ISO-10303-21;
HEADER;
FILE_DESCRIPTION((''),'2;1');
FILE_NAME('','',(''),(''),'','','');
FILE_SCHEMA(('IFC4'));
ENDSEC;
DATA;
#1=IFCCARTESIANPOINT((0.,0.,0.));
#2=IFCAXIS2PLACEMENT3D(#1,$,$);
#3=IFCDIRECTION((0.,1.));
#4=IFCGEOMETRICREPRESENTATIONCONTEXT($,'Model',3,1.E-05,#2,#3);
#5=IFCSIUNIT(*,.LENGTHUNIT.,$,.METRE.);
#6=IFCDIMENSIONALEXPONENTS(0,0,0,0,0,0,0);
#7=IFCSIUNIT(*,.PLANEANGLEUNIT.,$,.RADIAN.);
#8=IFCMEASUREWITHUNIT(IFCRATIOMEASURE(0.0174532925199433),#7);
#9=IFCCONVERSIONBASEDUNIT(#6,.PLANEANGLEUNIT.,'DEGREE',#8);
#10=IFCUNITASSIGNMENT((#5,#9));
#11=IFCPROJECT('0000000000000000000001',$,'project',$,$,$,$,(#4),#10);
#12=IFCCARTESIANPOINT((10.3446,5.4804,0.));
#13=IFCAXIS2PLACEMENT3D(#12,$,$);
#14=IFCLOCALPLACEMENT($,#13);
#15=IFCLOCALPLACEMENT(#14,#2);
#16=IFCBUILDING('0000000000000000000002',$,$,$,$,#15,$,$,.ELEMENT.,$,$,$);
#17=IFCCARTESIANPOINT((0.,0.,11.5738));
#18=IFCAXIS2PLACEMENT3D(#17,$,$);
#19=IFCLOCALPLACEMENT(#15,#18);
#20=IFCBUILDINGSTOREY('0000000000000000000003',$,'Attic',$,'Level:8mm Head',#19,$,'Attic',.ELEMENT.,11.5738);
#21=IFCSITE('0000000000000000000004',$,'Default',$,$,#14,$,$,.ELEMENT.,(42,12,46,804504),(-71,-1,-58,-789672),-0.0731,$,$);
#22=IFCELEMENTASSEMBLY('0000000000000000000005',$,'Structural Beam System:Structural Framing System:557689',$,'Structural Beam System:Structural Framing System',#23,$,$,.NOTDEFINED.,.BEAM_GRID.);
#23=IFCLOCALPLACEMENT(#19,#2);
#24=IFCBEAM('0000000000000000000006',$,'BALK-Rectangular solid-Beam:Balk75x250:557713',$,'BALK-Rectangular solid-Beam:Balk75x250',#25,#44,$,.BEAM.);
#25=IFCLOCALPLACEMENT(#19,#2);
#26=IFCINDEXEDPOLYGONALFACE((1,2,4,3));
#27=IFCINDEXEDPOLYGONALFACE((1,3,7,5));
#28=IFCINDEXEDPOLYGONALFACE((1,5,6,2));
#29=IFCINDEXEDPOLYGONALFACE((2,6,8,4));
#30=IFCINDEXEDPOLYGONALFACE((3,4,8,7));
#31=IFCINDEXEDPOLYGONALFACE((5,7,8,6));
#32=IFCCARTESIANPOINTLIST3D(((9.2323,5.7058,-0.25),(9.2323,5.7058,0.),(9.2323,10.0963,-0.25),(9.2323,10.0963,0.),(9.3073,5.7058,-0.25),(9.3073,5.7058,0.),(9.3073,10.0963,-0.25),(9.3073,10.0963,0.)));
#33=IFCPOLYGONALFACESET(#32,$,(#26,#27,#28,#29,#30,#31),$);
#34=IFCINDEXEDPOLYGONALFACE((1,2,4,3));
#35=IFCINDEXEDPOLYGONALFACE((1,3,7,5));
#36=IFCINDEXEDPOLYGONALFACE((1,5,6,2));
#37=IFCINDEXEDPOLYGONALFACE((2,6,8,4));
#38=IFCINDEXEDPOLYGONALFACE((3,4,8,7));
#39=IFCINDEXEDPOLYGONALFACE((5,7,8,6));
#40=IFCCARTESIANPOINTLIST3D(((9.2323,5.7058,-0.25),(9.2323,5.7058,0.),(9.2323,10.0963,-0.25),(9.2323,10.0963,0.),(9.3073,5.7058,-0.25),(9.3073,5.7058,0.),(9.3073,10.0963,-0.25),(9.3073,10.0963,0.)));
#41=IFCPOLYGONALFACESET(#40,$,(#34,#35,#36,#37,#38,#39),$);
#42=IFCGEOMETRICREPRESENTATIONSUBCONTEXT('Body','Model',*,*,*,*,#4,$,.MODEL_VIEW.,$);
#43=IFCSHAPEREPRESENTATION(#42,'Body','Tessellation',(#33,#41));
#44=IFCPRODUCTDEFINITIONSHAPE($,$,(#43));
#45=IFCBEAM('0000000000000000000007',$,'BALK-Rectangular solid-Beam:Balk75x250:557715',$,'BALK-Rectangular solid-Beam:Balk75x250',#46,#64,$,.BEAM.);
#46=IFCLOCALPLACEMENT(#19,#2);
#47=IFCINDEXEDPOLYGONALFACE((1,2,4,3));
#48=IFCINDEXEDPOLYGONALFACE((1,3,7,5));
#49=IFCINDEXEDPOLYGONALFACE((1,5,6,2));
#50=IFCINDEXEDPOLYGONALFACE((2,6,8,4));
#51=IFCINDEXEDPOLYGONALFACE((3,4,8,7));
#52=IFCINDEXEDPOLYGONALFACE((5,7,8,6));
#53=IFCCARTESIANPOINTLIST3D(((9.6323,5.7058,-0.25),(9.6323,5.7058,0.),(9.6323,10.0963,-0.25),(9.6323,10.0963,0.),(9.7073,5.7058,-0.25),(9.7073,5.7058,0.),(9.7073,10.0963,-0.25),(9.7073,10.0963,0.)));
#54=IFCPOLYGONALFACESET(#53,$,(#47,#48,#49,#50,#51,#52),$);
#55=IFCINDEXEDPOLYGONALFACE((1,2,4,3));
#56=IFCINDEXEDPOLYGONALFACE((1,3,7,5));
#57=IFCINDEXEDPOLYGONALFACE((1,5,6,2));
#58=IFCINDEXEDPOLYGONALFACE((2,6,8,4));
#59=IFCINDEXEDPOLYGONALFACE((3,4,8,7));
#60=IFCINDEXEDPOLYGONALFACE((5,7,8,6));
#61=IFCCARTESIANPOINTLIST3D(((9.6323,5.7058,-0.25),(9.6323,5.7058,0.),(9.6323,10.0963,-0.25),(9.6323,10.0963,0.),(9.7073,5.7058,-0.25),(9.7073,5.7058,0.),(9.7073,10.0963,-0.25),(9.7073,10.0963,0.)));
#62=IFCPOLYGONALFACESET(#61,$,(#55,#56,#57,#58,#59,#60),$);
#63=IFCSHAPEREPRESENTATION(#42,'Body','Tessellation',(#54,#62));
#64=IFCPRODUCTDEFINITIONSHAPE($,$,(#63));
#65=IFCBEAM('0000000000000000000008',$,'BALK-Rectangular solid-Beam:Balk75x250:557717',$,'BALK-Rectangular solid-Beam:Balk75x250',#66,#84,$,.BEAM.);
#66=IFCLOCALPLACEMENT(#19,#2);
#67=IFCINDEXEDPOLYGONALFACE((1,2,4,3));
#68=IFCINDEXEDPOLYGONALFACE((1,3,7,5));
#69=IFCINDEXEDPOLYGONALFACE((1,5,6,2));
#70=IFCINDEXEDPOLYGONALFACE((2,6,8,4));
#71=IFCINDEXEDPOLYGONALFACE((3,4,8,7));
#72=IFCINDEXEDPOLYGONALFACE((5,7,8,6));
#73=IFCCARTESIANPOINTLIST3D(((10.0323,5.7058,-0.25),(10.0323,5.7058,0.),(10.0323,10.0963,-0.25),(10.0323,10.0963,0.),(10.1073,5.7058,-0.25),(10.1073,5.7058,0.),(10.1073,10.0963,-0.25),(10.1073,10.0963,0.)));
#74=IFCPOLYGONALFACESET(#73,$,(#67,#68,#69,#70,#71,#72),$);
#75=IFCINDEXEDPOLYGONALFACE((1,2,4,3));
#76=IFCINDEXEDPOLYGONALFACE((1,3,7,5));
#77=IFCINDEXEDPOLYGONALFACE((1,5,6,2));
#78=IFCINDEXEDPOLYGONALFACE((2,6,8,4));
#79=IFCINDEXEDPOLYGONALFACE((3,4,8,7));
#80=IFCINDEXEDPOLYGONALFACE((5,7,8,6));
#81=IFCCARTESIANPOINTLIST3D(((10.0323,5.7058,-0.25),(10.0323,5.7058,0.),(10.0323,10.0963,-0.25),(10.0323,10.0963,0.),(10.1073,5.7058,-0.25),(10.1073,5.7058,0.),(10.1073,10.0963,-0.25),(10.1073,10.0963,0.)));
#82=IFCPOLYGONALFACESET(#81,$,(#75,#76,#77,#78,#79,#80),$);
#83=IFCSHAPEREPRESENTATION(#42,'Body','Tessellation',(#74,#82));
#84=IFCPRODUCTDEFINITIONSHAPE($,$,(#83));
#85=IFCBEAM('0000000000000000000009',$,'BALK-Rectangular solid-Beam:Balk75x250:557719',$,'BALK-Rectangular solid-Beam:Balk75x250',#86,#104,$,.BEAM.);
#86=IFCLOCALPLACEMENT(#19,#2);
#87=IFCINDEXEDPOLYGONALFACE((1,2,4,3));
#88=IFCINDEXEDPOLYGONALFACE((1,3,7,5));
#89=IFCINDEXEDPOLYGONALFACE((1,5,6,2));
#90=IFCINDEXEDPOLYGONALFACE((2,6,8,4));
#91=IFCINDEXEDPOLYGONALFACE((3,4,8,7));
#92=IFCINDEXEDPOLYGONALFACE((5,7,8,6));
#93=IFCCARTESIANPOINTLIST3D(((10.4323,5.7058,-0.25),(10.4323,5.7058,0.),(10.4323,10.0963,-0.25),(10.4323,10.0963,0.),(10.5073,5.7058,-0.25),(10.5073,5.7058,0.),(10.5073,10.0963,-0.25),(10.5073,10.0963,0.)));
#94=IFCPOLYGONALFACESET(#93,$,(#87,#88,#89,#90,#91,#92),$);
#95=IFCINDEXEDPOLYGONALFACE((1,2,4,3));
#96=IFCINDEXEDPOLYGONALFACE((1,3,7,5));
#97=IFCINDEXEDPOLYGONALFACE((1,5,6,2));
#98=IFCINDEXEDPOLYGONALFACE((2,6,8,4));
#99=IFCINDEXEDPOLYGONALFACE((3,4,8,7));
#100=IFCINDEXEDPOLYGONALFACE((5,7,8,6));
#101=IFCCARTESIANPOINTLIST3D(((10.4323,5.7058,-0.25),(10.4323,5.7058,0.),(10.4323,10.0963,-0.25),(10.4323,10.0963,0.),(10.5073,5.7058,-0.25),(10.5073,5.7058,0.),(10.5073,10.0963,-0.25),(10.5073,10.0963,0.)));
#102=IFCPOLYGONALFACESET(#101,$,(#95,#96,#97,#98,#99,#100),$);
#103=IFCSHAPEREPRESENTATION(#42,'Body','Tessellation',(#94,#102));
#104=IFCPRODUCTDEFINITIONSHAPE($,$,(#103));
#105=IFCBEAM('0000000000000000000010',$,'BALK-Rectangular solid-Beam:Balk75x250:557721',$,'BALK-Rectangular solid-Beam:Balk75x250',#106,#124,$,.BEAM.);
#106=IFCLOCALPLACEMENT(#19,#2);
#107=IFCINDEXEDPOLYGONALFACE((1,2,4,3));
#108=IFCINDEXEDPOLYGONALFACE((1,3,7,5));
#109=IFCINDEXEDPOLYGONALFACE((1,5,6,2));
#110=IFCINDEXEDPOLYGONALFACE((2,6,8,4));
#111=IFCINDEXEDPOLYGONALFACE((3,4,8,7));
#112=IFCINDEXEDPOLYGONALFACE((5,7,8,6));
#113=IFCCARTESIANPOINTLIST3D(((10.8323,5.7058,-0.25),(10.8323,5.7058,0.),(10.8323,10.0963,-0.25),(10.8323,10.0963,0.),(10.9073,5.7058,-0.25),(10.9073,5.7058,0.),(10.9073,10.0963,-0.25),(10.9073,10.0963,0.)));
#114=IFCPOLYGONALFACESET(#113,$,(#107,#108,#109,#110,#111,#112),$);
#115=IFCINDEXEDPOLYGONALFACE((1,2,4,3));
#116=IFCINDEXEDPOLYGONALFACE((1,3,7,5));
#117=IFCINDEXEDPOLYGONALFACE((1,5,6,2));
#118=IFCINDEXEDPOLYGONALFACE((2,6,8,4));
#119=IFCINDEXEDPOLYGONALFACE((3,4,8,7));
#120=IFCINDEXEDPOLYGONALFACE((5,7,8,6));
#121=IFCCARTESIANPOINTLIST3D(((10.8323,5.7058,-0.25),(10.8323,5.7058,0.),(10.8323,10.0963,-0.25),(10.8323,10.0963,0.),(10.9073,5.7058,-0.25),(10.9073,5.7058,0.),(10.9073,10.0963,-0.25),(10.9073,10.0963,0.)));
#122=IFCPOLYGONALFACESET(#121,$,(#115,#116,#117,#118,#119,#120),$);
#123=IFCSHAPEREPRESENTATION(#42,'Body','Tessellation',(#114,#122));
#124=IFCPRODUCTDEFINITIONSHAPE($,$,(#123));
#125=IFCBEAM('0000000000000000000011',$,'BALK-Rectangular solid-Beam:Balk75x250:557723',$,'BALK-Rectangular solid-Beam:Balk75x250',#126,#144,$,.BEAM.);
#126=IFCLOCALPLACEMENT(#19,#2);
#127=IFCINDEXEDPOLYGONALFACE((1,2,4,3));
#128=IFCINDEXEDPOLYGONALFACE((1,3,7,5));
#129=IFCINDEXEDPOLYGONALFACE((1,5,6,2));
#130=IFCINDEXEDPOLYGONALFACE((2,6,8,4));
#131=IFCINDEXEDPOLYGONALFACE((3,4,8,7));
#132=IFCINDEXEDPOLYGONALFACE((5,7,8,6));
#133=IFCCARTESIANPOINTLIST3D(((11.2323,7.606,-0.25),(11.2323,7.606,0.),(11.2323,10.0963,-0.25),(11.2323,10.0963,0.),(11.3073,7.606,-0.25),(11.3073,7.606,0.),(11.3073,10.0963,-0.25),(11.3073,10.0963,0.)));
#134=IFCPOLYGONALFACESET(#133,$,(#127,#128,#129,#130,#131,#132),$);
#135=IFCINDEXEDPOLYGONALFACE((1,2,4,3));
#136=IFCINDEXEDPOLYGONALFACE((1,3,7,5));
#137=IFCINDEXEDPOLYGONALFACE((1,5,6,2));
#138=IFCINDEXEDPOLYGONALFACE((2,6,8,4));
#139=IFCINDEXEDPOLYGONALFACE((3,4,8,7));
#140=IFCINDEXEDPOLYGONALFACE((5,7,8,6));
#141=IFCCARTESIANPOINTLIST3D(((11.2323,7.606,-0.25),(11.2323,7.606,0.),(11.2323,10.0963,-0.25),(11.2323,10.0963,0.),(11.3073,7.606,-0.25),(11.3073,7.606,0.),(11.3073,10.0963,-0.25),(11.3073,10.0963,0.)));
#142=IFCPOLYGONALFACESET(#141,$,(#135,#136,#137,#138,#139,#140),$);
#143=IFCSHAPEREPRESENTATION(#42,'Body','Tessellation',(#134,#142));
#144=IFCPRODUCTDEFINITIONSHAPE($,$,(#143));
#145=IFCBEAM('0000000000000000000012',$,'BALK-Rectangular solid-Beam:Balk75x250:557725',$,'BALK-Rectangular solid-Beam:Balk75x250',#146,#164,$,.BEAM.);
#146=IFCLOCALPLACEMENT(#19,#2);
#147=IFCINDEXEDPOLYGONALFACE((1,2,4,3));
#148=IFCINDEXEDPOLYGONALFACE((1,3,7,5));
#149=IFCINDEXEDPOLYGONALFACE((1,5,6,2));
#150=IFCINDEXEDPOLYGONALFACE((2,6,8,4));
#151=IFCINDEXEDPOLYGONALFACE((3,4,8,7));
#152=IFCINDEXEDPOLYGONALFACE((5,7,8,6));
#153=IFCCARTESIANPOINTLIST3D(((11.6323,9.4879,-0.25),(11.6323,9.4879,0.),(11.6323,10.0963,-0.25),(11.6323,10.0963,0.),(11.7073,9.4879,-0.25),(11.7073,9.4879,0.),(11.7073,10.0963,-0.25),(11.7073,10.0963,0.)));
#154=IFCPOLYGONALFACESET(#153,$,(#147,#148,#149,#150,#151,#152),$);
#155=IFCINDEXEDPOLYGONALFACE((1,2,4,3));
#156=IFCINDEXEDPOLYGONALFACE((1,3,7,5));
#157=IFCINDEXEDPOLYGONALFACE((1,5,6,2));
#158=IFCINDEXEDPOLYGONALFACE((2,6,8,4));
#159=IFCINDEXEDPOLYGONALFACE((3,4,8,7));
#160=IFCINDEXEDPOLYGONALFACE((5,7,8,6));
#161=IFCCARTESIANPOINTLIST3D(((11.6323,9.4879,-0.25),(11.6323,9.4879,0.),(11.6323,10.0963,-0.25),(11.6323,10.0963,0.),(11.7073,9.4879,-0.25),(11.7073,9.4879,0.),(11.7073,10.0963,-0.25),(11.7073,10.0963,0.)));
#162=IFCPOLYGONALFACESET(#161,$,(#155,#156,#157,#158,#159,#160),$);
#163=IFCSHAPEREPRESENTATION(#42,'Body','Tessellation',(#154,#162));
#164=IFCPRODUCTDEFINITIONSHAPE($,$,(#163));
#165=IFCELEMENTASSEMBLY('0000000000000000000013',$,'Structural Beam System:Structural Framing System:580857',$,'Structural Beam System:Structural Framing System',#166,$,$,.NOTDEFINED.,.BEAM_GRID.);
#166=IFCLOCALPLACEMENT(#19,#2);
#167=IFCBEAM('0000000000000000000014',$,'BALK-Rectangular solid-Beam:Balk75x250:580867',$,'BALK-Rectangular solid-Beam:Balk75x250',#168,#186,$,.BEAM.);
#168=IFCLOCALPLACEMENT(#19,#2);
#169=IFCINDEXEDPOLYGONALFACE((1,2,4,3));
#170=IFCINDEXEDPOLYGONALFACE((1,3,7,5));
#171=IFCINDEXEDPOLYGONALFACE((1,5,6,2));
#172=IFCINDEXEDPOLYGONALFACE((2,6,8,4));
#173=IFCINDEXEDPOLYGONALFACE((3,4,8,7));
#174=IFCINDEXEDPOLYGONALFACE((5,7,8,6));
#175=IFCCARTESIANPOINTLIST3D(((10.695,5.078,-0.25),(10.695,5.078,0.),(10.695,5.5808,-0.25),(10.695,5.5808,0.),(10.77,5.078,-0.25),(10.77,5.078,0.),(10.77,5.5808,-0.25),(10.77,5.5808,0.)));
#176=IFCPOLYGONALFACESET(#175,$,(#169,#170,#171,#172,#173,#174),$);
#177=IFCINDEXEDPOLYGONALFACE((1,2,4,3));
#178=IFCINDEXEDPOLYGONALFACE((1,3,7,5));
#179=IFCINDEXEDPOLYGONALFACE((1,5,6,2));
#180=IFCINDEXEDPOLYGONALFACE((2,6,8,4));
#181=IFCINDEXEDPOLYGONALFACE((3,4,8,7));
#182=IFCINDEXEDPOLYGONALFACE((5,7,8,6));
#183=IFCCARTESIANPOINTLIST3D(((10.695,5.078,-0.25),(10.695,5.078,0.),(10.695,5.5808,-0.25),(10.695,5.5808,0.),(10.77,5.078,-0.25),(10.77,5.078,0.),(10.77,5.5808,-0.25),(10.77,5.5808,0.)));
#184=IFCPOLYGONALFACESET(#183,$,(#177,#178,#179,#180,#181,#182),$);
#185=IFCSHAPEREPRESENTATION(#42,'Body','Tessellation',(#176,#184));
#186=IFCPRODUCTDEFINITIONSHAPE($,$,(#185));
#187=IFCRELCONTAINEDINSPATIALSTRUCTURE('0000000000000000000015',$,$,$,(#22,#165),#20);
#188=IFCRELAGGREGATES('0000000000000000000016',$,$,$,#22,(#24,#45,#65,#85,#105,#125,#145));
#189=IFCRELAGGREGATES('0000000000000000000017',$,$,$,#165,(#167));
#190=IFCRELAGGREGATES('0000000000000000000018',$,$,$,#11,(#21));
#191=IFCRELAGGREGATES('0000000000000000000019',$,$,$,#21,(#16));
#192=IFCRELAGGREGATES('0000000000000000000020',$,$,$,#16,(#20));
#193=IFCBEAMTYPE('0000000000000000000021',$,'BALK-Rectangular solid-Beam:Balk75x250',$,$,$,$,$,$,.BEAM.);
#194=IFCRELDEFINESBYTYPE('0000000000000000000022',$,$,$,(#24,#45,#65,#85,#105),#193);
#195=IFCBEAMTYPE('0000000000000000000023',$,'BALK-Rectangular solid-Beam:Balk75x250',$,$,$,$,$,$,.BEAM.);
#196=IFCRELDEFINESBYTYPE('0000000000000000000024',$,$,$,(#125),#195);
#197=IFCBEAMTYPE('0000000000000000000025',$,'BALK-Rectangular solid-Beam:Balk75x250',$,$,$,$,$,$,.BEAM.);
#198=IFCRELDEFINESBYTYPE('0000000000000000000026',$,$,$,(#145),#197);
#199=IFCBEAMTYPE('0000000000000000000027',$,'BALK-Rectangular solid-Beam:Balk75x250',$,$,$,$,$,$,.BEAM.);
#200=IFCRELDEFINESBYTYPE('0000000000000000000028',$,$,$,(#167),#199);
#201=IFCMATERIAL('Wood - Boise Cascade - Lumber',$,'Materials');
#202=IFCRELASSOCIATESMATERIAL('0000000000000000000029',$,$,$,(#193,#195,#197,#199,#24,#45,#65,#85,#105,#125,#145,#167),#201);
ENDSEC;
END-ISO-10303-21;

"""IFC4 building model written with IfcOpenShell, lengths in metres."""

from ifc_helpers import new_model, entity, si_unit, converted_unit, direction, frame, frame_2d, origin, origin_2d_with_axis, place, context, subcontext, project, spatial, rectangle, extrude, source, transform, mapped, material, material_profile, profile_set, profile_usage, type_object, type_shapes, element, aggregate, save


model = new_model("IFC4")

# Units and contexts
model_context = context("Model", 3, precision=1e-05, world=origin(), true_north=direction((0.0, 1.0)))
body_context = subcontext(model_context, "Body", "Model", "MODEL_VIEW")
ifc_project = project(units=[si_unit("LENGTHUNIT", "METRE"), converted_unit("PLANEANGLEUNIT", "DEGREE", entity("IfcRatioMeasure", 0.0174532925199433), si_unit("PLANEANGLEUNIT", "RADIAN"), dimensions=[0, 0, 0, 0, 0, 0, 0])], contexts=[model_context])

# Site, building, storey
site_placement = place(None, frame((10.3446, 5.4804, 0.0)))
site = spatial("IfcSite", under=ifc_project, at=site_placement, Name="Default", CompositionType="ELEMENT", RefLatitude=(42, 12, 46, 804504), RefLongitude=(-71, -1, -58, -789672), RefElevation=-0.0731)
building_placement = place(site_placement, origin())
building = spatial("IfcBuilding", under=site, at=building_placement, CompositionType="ELEMENT")
storey_placement = place(building_placement, frame((0.0, 0.0, 11.5738)))
storey = spatial("IfcBuildingStorey", under=building, at=storey_placement, Name="Attic", ObjectType="Level:8mm Head", LongName="Attic", CompositionType="ELEMENT", Elevation=11.5738)

# Element assembly, beams
assembly_1_placement = place(storey_placement, origin())
assembly_1 = element("IfcElementAssembly", 1, at=assembly_1_placement, inside=storey, Name="Structural Beam System:Structural Framing System:557689", ObjectType="Structural Beam System:Structural Framing System", AssemblyPlace="NOTDEFINED", PredefinedType="BEAM_GRID")
ifc_material = material(Name="Wood - Boise Cascade - Lumber", Category="Materials")
ifc_material_profile = material_profile(ifc_material, rectangle(XDim=0.25, YDim=0.075, at=frame_2d((0.0, 0.0), x_axis=(1.0, 0.0))), Name="Balk75x250")
ifc_profile_set = profile_set([ifc_material_profile], Name="Balk75x250")
beam_type_1 = type_object("IfcBeamType", Name="BALK-Rectangular solid-Beam:Balk75x250", PredefinedType="BEAM", material=ifc_profile_set)
shared_shape_1 = source(origin(), body_context, "Body", "SweptSolid", [
    extrude(rectangle(XDim=0.25, YDim=0.075, at=origin_2d_with_axis()), frame((-2.3015, 0.0, 0.0), z_axis=(1.0, 0.0, 0.0), x_axis=(0.0, 0.0, -1.0)), (0.0, 0.0, 1.0), 4.3905),
    extrude(rectangle(XDim=0.25, YDim=0.075, at=origin_2d_with_axis()), frame((-2.3015, 0.0, 0.0), z_axis=(1.0, 0.0, 0.0), x_axis=(0.0, 0.0, -1.0)), (0.0, 0.0, 1.0), 4.3905),
])
type_shapes(beam_type_1, [shared_shape_1])
ifc_profile_usage_1 = profile_usage(ifc_profile_set, cardinal=8)
beam_1_placement = place(assembly_1_placement, frame((9.2698, 8.0073, -0.125), z_axis=(0.0, 0.0, 1.0), x_axis=(0.0, 1.0, 0.0)))
beam_1 = element("IfcBeam", 2, at=beam_1_placement, type_object=beam_type_1, material=ifc_profile_usage_1, Name="BALK-Rectangular solid-Beam:Balk75x250:557713", ObjectType="BALK-Rectangular solid-Beam:Balk75x250", PredefinedType="BEAM", context=body_context, shape_type="MappedRepresentation", body=[
    mapped(shared_shape_1, transform((0.0, 0.0, 0.0), scale=1.0)),
])
ifc_profile_usage_2 = profile_usage(ifc_profile_set, cardinal=8)
beam_2_placement = place(assembly_1_placement, frame((9.6698, 8.0073, -0.125), z_axis=(0.0, 0.0, 1.0), x_axis=(0.0, 1.0, 0.0)))
beam_2 = element("IfcBeam", 3, at=beam_2_placement, type_object=beam_type_1, material=ifc_profile_usage_2, Name="BALK-Rectangular solid-Beam:Balk75x250:557715", ObjectType="BALK-Rectangular solid-Beam:Balk75x250", PredefinedType="BEAM", context=body_context, shape_type="MappedRepresentation", body=[
    mapped(shared_shape_1, transform((0.0, 0.0, 0.0), scale=1.0)),
])
ifc_profile_usage_3 = profile_usage(ifc_profile_set, cardinal=8)
beam_3_placement = place(assembly_1_placement, frame((10.0698, 8.0073, -0.125), z_axis=(0.0, 0.0, 1.0), x_axis=(0.0, 1.0, 0.0)))
beam_3 = element("IfcBeam", 4, at=beam_3_placement, type_object=beam_type_1, material=ifc_profile_usage_3, Name="BALK-Rectangular solid-Beam:Balk75x250:557717", ObjectType="BALK-Rectangular solid-Beam:Balk75x250", PredefinedType="BEAM", context=body_context, shape_type="MappedRepresentation", body=[
    mapped(shared_shape_1, transform((0.0, 0.0, 0.0), scale=1.0)),
])
ifc_profile_usage_4 = profile_usage(ifc_profile_set, cardinal=8)
beam_4_placement = place(assembly_1_placement, frame((10.4698, 8.0073, -0.125), z_axis=(0.0, 0.0, 1.0), x_axis=(0.0, 1.0, 0.0)))
beam_4 = element("IfcBeam", 5, at=beam_4_placement, type_object=beam_type_1, material=ifc_profile_usage_4, Name="BALK-Rectangular solid-Beam:Balk75x250:557719", ObjectType="BALK-Rectangular solid-Beam:Balk75x250", PredefinedType="BEAM", context=body_context, shape_type="MappedRepresentation", body=[
    mapped(shared_shape_1, transform((0.0, 0.0, 0.0), scale=1.0)),
])
ifc_profile_usage_5 = profile_usage(ifc_profile_set, cardinal=8)
beam_5_placement = place(assembly_1_placement, frame((10.8698, 8.0073, -0.125), z_axis=(0.0, 0.0, 1.0), x_axis=(0.0, 1.0, 0.0)))
beam_5 = element("IfcBeam", 6, at=beam_5_placement, type_object=beam_type_1, material=ifc_profile_usage_5, Name="BALK-Rectangular solid-Beam:Balk75x250:557721", ObjectType="BALK-Rectangular solid-Beam:Balk75x250", PredefinedType="BEAM", context=body_context, shape_type="MappedRepresentation", body=[
    mapped(shared_shape_1, transform((0.0, 0.0, 0.0), scale=1.0)),
])
ifc_profile_usage_6 = profile_usage(ifc_profile_set, cardinal=8)
beam_type_2 = type_object("IfcBeamType", Name="BALK-Rectangular solid-Beam:Balk75x250", PredefinedType="BEAM", material=ifc_profile_set)
shared_shape_2 = source(origin(), body_context, "Body", "SweptSolid", [
    extrude(rectangle(XDim=0.25, YDim=0.075, at=origin_2d_with_axis()), frame((-0.6331, 0.0, 0.0), z_axis=(1.0, 0.0, 0.0), x_axis=(0.0, 0.0, -1.0)), (0.0, 0.0, 1.0), 2.4903),
    extrude(rectangle(XDim=0.25, YDim=0.075, at=origin_2d_with_axis()), frame((-0.6331, 0.0, 0.0), z_axis=(1.0, 0.0, 0.0), x_axis=(0.0, 0.0, -1.0)), (0.0, 0.0, 1.0), 2.4903),
])
type_shapes(beam_type_2, [shared_shape_2])
beam_6_placement = place(assembly_1_placement, frame((11.2698, 8.2391, -0.125), z_axis=(0.0, 0.0, 1.0), x_axis=(0.0, 1.0, 0.0)))
beam_6 = element("IfcBeam", 7, at=beam_6_placement, type_object=beam_type_2, material=ifc_profile_usage_6, Name="BALK-Rectangular solid-Beam:Balk75x250:557723", ObjectType="BALK-Rectangular solid-Beam:Balk75x250", PredefinedType="BEAM", context=body_context, shape_type="MappedRepresentation", body=[
    mapped(shared_shape_2, transform((0.0, 0.0, 0.0), scale=1.0)),
])
ifc_profile_usage_7 = profile_usage(ifc_profile_set, cardinal=8)
beam_type_3 = type_object("IfcBeamType", Name="BALK-Rectangular solid-Beam:Balk75x250", PredefinedType="BEAM", material=ifc_profile_set)
shared_shape_3 = source(origin(), body_context, "Body", "SweptSolid", [
    extrude(rectangle(XDim=0.25, YDim=0.075, at=origin_2d_with_axis()), frame((0.3078, 0.0, 0.0), z_axis=(1.0, 0.0, 0.0), x_axis=(0.0, 0.0, -1.0)), (0.0, 0.0, 1.0), 0.6084),
    extrude(rectangle(XDim=0.25, YDim=0.075, at=origin_2d_with_axis()), frame((0.3078, 0.0, 0.0), z_axis=(1.0, 0.0, 0.0), x_axis=(0.0, 0.0, -1.0)), (0.0, 0.0, 1.0), 0.6084),
])
type_shapes(beam_type_3, [shared_shape_3])
beam_7_placement = place(assembly_1_placement, frame((11.6698, 9.18, -0.125), z_axis=(0.0, 0.0, 1.0), x_axis=(0.0, 1.0, 0.0)))
beam_7 = element("IfcBeam", 8, at=beam_7_placement, type_object=beam_type_3, material=ifc_profile_usage_7, Name="BALK-Rectangular solid-Beam:Balk75x250:557725", ObjectType="BALK-Rectangular solid-Beam:Balk75x250", PredefinedType="BEAM", context=body_context, shape_type="MappedRepresentation", body=[
    mapped(shared_shape_3, transform((0.0, 0.0, 0.0), scale=1.0)),
])
aggregate(assembly_1, [beam_1, beam_2, beam_3, beam_4, beam_5, beam_6, beam_7])

# Element assembly, beam
assembly_2_placement = place(storey_placement, origin())
assembly_2 = element("IfcElementAssembly", 9, at=assembly_2_placement, inside=storey, Name="Structural Beam System:Structural Framing System:580857", ObjectType="Structural Beam System:Structural Framing System", AssemblyPlace="NOTDEFINED", PredefinedType="BEAM_GRID")
ifc_profile_usage_8 = profile_usage(ifc_profile_set, cardinal=8)
beam_type_4 = type_object("IfcBeamType", Name="BALK-Rectangular solid-Beam:Balk75x250", PredefinedType="BEAM", material=ifc_profile_set)
shared_shape_4 = source(origin(), body_context, "Body", "SweptSolid", [
    extrude(rectangle(XDim=0.25, YDim=0.075, at=origin_2d_with_axis()), frame((-0.9697, 0.0, 0.0), z_axis=(1.0, 0.0, 0.0), x_axis=(0.0, 0.0, -1.0)), (0.0, 0.0, 1.0), 0.5028),
    extrude(rectangle(XDim=0.25, YDim=0.075, at=origin_2d_with_axis()), frame((-0.9697, 0.0, 0.0), z_axis=(1.0, 0.0, 0.0), x_axis=(0.0, 0.0, -1.0)), (0.0, 0.0, 1.0), 0.5028),
])
type_shapes(beam_type_4, [shared_shape_4])
beam_8_placement = place(assembly_2_placement, frame((10.7325, 4.6111, -0.125), z_axis=(0.0, 0.0, 1.0), x_axis=(0.0, -1.0, 0.0)))
beam_8 = element("IfcBeam", 10, at=beam_8_placement, type_object=beam_type_4, material=ifc_profile_usage_8, Name="BALK-Rectangular solid-Beam:Balk75x250:580867", ObjectType="BALK-Rectangular solid-Beam:Balk75x250", PredefinedType="BEAM", context=body_context, shape_type="MappedRepresentation", body=[
    mapped(shared_shape_4, transform((0.0, 0.0, 0.0), scale=1.0)),
])

aggregate(assembly_2, [beam_8])

save(model, "model.ifc")
